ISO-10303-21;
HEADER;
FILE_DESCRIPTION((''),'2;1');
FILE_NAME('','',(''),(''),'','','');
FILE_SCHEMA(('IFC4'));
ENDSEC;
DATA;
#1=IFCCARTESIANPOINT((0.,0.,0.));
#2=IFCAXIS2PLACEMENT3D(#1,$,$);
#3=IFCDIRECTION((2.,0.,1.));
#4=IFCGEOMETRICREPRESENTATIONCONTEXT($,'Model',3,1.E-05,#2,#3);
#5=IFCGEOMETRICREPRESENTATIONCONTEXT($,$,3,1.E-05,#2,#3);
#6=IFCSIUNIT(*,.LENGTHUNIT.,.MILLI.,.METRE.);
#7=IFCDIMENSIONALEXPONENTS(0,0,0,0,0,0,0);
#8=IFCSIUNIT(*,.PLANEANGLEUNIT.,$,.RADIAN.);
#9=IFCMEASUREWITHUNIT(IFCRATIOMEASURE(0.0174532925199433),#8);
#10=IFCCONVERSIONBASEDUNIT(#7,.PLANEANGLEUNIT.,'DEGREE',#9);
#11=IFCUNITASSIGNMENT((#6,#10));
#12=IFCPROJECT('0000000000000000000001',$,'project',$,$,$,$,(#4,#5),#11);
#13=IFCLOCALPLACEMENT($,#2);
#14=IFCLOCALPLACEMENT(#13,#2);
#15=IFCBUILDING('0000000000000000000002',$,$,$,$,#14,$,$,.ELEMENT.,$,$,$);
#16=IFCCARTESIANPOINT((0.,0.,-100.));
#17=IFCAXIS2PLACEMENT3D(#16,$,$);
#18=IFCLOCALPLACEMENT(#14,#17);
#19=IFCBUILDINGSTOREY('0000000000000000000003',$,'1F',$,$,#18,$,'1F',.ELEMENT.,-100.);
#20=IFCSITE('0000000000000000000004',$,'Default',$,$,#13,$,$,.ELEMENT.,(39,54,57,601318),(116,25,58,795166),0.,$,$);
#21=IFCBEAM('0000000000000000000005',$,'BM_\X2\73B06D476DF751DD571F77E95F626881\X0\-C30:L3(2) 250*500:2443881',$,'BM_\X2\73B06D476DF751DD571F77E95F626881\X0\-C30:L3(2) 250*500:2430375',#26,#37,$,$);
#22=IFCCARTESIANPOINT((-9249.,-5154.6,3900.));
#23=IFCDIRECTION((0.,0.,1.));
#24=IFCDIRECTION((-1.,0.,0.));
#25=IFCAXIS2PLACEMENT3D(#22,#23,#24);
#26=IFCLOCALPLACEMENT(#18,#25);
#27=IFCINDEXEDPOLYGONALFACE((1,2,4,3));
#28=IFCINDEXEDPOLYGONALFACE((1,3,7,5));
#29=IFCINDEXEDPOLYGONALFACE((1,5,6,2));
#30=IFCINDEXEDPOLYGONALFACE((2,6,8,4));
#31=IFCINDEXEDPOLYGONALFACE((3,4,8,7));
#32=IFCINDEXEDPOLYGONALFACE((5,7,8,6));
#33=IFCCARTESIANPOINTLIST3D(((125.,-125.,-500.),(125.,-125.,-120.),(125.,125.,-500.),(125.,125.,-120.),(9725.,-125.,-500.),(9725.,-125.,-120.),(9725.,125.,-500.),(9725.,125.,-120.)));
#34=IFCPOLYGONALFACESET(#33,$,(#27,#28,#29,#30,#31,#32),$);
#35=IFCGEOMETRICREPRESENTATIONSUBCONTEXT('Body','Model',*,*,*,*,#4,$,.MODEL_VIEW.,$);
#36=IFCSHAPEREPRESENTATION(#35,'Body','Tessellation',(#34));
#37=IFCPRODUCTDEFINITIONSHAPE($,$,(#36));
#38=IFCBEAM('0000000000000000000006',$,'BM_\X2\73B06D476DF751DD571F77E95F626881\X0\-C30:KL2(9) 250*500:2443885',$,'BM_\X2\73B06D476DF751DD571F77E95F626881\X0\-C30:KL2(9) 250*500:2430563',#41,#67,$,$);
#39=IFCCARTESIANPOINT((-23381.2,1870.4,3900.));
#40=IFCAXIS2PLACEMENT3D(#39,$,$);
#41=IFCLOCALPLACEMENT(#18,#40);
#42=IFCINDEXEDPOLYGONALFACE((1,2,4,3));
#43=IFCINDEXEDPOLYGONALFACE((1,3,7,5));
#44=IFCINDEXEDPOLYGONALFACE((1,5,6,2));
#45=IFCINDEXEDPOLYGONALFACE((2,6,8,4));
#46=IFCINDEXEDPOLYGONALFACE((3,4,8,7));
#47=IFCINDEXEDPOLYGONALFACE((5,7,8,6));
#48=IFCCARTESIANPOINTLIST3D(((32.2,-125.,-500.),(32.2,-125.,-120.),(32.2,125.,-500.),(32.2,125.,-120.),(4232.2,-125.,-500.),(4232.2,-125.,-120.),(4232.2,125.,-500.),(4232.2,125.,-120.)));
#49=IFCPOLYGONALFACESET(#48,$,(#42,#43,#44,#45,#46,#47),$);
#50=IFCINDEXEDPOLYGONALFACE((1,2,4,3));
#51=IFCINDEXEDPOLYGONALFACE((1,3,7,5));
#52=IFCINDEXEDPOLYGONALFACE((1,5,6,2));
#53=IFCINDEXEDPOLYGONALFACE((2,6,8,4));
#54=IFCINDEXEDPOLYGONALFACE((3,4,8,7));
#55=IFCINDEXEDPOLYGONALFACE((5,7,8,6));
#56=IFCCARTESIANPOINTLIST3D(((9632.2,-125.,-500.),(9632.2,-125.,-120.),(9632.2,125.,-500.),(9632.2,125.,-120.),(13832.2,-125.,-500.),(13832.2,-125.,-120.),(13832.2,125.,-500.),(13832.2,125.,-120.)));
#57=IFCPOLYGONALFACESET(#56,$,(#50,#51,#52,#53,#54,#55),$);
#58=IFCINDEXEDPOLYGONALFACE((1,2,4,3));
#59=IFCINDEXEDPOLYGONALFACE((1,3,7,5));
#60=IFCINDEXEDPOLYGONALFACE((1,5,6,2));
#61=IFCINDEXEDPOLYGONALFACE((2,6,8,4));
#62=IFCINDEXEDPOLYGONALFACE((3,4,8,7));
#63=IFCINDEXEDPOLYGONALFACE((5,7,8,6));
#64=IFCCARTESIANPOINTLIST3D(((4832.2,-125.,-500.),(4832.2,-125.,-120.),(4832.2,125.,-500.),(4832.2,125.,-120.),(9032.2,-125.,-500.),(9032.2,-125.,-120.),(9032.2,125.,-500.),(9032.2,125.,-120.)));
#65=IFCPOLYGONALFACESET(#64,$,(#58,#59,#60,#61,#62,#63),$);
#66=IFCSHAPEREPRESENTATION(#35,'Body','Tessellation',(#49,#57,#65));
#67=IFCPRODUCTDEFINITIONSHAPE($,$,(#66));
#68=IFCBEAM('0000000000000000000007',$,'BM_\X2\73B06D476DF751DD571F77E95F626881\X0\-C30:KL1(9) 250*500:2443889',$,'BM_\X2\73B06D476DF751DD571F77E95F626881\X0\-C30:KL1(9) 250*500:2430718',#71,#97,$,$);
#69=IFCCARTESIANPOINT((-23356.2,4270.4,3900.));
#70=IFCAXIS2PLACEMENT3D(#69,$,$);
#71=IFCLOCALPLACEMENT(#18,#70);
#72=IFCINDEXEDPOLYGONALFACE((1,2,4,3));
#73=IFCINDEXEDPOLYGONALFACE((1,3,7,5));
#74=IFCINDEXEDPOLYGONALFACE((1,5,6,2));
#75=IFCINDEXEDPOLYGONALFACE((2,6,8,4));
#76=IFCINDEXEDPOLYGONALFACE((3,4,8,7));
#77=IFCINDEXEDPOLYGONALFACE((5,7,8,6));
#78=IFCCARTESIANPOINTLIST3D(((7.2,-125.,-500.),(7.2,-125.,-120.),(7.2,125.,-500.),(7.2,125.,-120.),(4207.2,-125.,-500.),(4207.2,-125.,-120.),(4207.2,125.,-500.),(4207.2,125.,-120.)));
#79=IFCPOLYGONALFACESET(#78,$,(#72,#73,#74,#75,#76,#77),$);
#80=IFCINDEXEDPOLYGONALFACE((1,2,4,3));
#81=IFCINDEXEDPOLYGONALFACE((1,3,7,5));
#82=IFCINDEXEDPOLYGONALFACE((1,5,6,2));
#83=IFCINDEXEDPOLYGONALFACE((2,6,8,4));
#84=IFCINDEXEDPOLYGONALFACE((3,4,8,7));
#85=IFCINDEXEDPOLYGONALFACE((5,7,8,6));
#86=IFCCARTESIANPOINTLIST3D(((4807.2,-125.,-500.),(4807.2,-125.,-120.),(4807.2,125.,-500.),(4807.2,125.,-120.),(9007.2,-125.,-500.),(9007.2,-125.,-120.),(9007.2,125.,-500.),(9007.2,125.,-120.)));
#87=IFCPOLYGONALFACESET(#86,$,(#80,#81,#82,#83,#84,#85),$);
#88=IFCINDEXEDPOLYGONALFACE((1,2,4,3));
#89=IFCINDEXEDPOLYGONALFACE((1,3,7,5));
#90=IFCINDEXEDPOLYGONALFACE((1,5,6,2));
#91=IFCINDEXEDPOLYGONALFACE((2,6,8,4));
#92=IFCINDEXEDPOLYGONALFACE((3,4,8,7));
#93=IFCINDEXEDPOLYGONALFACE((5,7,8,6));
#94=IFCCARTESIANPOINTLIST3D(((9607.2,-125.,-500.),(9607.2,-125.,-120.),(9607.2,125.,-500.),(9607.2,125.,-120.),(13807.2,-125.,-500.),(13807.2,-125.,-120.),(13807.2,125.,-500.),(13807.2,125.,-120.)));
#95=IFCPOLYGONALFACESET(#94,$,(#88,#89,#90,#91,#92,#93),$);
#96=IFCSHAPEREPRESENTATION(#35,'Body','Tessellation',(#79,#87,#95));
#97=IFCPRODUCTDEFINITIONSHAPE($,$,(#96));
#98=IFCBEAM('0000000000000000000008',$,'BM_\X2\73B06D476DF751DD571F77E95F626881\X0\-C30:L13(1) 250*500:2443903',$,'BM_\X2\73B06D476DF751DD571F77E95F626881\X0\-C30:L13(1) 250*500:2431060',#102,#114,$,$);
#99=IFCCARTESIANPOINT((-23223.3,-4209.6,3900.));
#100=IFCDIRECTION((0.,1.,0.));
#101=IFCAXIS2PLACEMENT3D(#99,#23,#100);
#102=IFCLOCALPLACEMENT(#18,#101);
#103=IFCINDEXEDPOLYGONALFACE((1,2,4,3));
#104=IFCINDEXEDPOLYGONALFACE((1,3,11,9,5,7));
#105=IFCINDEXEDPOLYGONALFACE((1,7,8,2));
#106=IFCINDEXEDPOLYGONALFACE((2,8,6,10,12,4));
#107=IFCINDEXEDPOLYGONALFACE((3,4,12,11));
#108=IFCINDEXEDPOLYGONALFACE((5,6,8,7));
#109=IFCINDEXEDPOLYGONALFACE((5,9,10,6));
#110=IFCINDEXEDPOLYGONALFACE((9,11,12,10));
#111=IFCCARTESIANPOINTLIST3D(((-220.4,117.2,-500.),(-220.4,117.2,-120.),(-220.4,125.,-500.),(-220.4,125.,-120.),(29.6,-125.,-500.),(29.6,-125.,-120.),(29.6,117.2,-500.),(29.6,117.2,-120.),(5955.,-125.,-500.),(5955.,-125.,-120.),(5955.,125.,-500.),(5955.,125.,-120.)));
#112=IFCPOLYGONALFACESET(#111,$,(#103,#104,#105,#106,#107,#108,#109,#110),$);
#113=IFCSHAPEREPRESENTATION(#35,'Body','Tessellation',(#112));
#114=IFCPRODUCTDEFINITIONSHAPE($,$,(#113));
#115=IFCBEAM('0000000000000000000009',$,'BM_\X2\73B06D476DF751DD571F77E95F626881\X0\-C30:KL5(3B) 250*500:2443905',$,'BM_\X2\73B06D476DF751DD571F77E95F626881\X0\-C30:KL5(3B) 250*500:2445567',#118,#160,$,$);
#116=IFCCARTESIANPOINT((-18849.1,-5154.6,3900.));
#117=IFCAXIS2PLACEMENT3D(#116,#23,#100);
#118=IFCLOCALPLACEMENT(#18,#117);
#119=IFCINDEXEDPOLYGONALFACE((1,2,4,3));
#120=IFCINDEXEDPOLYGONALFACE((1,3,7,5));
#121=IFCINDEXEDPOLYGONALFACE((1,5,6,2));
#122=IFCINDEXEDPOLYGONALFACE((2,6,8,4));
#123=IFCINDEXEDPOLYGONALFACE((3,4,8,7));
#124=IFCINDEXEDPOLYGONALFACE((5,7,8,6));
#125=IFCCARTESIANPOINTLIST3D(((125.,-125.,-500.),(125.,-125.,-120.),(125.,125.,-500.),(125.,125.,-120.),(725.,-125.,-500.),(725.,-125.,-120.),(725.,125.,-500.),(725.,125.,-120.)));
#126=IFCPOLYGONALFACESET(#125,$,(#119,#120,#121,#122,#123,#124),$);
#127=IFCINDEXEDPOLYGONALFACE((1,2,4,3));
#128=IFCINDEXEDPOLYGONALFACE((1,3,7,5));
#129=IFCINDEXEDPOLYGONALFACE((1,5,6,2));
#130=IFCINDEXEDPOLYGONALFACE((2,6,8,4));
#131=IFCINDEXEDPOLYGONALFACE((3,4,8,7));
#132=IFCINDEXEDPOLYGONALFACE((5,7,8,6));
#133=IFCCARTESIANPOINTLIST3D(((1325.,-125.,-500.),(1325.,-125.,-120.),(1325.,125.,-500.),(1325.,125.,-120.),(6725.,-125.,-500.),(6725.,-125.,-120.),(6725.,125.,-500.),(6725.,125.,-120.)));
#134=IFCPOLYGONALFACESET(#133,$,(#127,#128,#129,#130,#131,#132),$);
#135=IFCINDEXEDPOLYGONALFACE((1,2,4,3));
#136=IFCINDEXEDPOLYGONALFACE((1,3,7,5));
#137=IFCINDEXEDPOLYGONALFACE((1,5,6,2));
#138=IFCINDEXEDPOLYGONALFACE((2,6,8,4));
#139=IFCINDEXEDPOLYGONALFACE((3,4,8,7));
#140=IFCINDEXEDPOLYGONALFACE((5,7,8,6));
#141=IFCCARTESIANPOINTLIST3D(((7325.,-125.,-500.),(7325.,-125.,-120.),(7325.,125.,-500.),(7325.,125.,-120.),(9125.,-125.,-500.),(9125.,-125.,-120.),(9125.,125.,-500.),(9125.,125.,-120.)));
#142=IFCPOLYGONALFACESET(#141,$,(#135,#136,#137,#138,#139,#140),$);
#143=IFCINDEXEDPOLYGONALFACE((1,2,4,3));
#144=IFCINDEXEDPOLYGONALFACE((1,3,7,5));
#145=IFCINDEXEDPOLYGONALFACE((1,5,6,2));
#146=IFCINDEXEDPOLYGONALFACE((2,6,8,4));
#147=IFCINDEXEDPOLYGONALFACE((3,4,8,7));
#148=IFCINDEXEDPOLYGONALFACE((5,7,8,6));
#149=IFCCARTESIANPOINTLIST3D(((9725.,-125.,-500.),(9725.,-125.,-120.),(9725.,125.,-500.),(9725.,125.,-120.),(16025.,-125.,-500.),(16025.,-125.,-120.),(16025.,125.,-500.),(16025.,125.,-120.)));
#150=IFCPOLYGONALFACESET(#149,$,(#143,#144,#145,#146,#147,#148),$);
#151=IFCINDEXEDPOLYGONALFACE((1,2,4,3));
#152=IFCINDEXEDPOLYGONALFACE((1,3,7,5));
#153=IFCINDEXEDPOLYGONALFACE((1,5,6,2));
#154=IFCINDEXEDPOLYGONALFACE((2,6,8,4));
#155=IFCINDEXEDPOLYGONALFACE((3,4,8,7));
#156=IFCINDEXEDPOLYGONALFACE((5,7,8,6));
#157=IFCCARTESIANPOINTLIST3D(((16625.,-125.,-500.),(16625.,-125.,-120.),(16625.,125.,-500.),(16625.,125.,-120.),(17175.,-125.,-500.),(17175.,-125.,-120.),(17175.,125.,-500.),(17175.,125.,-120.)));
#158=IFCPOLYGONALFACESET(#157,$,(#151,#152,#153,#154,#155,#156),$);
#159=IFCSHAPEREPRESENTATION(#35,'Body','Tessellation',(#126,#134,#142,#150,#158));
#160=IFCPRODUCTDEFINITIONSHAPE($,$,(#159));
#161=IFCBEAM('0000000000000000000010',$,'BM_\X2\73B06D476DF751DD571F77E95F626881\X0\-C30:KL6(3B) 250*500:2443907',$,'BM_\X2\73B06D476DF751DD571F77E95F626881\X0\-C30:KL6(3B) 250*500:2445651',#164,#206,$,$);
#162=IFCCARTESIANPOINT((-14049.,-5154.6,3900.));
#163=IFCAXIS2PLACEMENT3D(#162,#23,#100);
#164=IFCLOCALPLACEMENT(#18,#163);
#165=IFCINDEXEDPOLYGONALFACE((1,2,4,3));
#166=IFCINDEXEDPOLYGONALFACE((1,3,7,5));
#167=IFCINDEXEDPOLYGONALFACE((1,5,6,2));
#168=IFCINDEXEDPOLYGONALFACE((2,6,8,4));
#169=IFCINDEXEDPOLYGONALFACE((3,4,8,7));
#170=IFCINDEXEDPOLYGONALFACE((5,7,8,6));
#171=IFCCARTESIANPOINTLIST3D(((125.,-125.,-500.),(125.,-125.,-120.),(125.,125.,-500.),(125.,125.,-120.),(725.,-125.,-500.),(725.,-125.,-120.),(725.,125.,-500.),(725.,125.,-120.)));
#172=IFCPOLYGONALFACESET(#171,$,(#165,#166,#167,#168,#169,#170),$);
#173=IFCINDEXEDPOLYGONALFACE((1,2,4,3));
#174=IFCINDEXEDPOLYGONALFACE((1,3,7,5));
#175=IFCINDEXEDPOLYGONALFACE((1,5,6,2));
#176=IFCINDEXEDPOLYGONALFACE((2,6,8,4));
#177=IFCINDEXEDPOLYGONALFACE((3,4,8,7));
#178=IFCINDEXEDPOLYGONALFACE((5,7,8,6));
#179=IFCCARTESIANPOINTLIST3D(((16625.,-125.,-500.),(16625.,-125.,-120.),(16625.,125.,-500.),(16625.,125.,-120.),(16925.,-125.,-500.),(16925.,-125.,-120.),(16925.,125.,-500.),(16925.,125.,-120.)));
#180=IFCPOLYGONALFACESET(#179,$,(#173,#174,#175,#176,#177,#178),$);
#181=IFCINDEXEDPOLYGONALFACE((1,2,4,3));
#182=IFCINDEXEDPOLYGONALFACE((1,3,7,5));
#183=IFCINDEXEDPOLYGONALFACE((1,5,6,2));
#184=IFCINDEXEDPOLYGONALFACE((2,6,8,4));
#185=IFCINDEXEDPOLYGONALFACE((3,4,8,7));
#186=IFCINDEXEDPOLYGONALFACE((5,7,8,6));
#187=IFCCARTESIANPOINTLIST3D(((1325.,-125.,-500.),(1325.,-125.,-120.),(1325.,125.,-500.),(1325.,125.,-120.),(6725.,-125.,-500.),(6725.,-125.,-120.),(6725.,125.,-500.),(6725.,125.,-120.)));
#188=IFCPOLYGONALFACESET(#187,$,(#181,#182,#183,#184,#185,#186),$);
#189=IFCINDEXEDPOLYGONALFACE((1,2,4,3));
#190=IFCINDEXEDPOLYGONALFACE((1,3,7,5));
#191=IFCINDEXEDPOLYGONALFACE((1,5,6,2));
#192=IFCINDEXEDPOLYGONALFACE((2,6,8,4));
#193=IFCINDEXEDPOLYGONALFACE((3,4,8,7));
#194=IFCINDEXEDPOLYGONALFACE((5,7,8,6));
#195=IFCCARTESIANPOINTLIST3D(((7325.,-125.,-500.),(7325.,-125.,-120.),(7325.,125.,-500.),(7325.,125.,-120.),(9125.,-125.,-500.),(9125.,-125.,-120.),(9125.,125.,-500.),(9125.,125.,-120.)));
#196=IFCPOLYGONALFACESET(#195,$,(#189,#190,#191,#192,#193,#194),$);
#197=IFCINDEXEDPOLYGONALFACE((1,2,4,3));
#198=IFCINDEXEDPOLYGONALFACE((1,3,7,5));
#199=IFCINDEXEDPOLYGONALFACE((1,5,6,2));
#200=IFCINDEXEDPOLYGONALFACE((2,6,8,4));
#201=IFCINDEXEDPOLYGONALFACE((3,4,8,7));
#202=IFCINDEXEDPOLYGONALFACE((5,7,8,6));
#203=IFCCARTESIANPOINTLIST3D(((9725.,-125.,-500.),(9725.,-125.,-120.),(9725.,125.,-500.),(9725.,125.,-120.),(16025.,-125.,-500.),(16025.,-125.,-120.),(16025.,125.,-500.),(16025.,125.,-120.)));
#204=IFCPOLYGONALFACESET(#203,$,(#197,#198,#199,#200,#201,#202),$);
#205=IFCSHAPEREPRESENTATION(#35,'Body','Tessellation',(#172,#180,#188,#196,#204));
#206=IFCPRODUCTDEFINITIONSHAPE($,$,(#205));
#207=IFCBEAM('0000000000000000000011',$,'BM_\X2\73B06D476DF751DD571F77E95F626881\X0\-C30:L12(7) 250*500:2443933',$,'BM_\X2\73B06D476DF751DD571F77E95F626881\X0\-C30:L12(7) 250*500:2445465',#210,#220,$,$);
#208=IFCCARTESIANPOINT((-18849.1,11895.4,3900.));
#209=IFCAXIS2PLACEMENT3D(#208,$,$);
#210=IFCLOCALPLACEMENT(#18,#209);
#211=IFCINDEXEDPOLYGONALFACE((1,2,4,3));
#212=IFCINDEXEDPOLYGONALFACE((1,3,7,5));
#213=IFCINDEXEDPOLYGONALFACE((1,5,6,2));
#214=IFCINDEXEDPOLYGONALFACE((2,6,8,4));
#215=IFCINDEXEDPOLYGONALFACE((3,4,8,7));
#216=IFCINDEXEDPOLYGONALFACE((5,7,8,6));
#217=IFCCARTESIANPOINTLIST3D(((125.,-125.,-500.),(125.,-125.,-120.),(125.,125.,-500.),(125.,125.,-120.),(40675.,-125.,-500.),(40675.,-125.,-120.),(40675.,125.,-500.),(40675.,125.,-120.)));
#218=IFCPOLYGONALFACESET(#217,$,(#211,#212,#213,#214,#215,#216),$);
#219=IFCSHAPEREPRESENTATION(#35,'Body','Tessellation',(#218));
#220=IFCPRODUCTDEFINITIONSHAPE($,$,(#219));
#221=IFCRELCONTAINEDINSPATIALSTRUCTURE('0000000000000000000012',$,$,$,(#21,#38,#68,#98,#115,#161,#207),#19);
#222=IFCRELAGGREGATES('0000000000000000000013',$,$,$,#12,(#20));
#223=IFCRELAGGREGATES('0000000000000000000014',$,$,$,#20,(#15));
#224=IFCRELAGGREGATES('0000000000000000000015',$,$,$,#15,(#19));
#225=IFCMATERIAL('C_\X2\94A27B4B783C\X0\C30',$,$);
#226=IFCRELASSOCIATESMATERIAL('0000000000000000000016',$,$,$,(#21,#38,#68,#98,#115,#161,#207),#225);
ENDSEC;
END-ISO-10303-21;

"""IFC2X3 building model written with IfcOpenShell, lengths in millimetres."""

from ifc_helpers import new_model, entity, si_unit, converted_unit, direction, frame, frame_2d, origin, origin_2d_with_axis, place, context, subcontext, project, spatial, polyline, rectangle, extrude, clip, bounded_halfspace, material, element, save


model = new_model("IFC2X3")

# Units and contexts
model_context = context("Model", 3, precision=1e-05, world=origin(), true_north=direction((2.0, 0.0, 1.0)))
context_of_model = context(None, 3, precision=1e-05, world=origin(), true_north=direction((2.0, 0.0, 1.0)))
body_context = subcontext(model_context, "Body", "Model", "MODEL_VIEW")
ifc_project = project(units=[si_unit("LENGTHUNIT", "METRE", prefix="MILLI"), converted_unit("PLANEANGLEUNIT", "DEGREE", entity("IfcRatioMeasure", 0.0174532925199433), si_unit("PLANEANGLEUNIT", "RADIAN"), dimensions=[0, 0, 0, 0, 0, 0, 0])], contexts=[model_context, context_of_model])

# Site, building, storey
site_placement = place(None, origin())
site = spatial("IfcSite", under=ifc_project, at=site_placement, Name="Default", CompositionType="ELEMENT", RefLatitude=(39, 54, 57, 601318), RefLongitude=(116, 25, 58, 795166), RefElevation=0.0)
building_placement = place(site_placement, origin())
building = spatial("IfcBuilding", under=site, at=building_placement, CompositionType="ELEMENT")
storey_placement = place(building_placement, frame((0.0, 0.0, -100.0)))
storey = spatial("IfcBuildingStorey", under=building, at=storey_placement, Name="1F", LongName="1F", CompositionType="ELEMENT", Elevation=-100.0)

# Beams
ifc_material = material(Name="C_钢筋砼C30")
beam_1_placement = place(storey_placement, frame((-9249.0, -5154.6, 3900.0), z_axis=(0.0, 0.0, 1.0), x_axis=(-1.0, 0.0, 0.0)))
element("IfcBeam", 1, at=beam_1_placement, inside=storey, material=ifc_material, Name="BM_现浇混凝土矩形梁-C30:L3(2) 250*500:2443881", ObjectType="BM_现浇混凝土矩形梁-C30:L3(2) 250*500:2430375", context=body_context, shape_type="SweptSolid", body=[
    extrude(rectangle(XDim=380.0, YDim=250.0, at=frame_2d((0.0, 0.0), x_axis=(1.0, 0.0))), frame((125.0, 0.0, -310.0), z_axis=(1.0, 0.0, 0.0), x_axis=(0.0, 0.0, -1.0)), (0.0, 0.0, 1.0), 9600.0),
])
beam_2_placement = place(storey_placement, frame((-23381.2, 1870.4, 3900.0)))
element("IfcBeam", 2, at=beam_2_placement, inside=storey, material=ifc_material, Name="BM_现浇混凝土矩形梁-C30:KL2(9) 250*500:2443885", ObjectType="BM_现浇混凝土矩形梁-C30:KL2(9) 250*500:2430563", context=body_context, shape_type="SweptSolid", body=[
    extrude(rectangle(XDim=380.0, YDim=250.0, at=frame_2d((0.0, 0.0), x_axis=(1.0, 0.0))), frame((32.2, 0.0, -310.0), z_axis=(1.0, 0.0, 0.0), x_axis=(0.0, 0.0, 1.0)), (0.0, 0.0, 1.0), 4200.0),
    extrude(rectangle(XDim=380.0, YDim=250.0, at=frame_2d((0.0, 0.0), x_axis=(1.0, 0.0))), frame((9632.2, 0.0, -310.0), z_axis=(1.0, 0.0, 0.0), x_axis=(0.0, 0.0, 1.0)), (0.0, 0.0, 1.0), 4200.0),
    extrude(rectangle(XDim=380.0, YDim=250.0, at=origin_2d_with_axis()), frame((4832.2, 0.0, -310.0), z_axis=(1.0, 0.0, 0.0), x_axis=(0.0, 0.0, 1.0)), (0.0, 0.0, 1.0), 4200.0),
])
beam_3_placement = place(storey_placement, frame((-23356.2, 4270.4, 3900.0)))
element("IfcBeam", 3, at=beam_3_placement, inside=storey, material=ifc_material, Name="BM_现浇混凝土矩形梁-C30:KL1(9) 250*500:2443889", ObjectType="BM_现浇混凝土矩形梁-C30:KL1(9) 250*500:2430718", context=body_context, shape_type="SweptSolid", body=[
    extrude(rectangle(XDim=380.0, YDim=250.0, at=origin_2d_with_axis()), frame((7.2, 0.0, -310.0), z_axis=(1.0, 0.0, 0.0), x_axis=(0.0, 0.0, 1.0)), (0.0, 0.0, 1.0), 4200.0),
    extrude(rectangle(XDim=380.0, YDim=250.0, at=frame_2d((0.0, 0.0), x_axis=(1.0, 0.0))), frame((4807.2, 0.0, -310.0), z_axis=(1.0, 0.0, 0.0), x_axis=(0.0, 0.0, 1.0)), (0.0, 0.0, 1.0), 4200.0),
    extrude(rectangle(XDim=380.0, YDim=250.0, at=origin_2d_with_axis()), frame((9607.2, 0.0, -310.0), z_axis=(1.0, 0.0, 0.0), x_axis=(0.0, 0.0, 1.0)), (0.0, 0.0, 1.0), 4200.0),
])
beam_4_placement = place(storey_placement, frame((-23223.3, -4209.6, 3900.0), z_axis=(0.0, 0.0, 1.0), x_axis=(0.0, 1.0, 0.0)))
element("IfcBeam", 4, at=beam_4_placement, inside=storey, material=ifc_material, Name="BM_现浇混凝土矩形梁-C30:L13(1) 250*500:2443903", ObjectType="BM_现浇混凝土矩形梁-C30:L13(1) 250*500:2431060", context=body_context, shape_type="Clipping", body=[
    clip(extrude(rectangle(XDim=380.0, YDim=250.0, at=origin_2d_with_axis()), frame((-220.4, 0.0, -310.0), z_axis=(1.0, 0.0, 0.0), x_axis=(0.0, 0.0, -1.0)), (0.0, 0.0, 1.0), 6175.4), bounded_halfspace(frame((29.6, 104.5, 0.0), z_axis=(-1.0, 0.0, 0.0), x_axis=(0.0, 0.0, -1.0)), False, frame((-220.4, 0.0, -310.0), z_axis=(1.0, 0.0, 0.0), x_axis=(0.0, 0.0, -1.0)), polyline([(190.0, 117.2), (190.0, -125.0), (-190.0, -125.0), (-190.0, 117.2), (190.0, 117.2)]))),
])
beam_5_placement = place(storey_placement, frame((-18849.1, -5154.6, 3900.0), z_axis=(0.0, 0.0, 1.0), x_axis=(0.0, 1.0, 0.0)))
element("IfcBeam", 5, at=beam_5_placement, inside=storey, material=ifc_material, Name="BM_现浇混凝土矩形梁-C30:KL5(3B) 250*500:2443905", ObjectType="BM_现浇混凝土矩形梁-C30:KL5(3B) 250*500:2445567", context=body_context, shape_type="SweptSolid", body=[
    extrude(rectangle(XDim=380.0, YDim=250.0, at=origin_2d_with_axis()), frame((125.0, 0.0, -310.0), z_axis=(1.0, 0.0, 0.0), x_axis=(0.0, 0.0, 1.0)), (0.0, 0.0, 1.0), 600.0),
    extrude(rectangle(XDim=380.0, YDim=250.0, at=origin_2d_with_axis()), frame((1325.0, 0.0, -310.0), z_axis=(1.0, 0.0, 0.0), x_axis=(0.0, 0.0, 1.0)), (0.0, 0.0, 1.0), 5400.0),
    extrude(rectangle(XDim=380.0, YDim=250.0, at=frame_2d((0.0, 0.0), x_axis=(1.0, 0.0))), frame((7325.0, 0.0, -310.0), z_axis=(1.0, 0.0, 0.0), x_axis=(0.0, 0.0, 1.0)), (0.0, 0.0, 1.0), 1800.0),
    extrude(rectangle(XDim=380.0, YDim=250.0, at=frame_2d((0.0, 0.0), x_axis=(1.0, 0.0))), frame((9725.0, 0.0, -310.0), z_axis=(1.0, 0.0, 0.0), x_axis=(0.0, 0.0, 1.0)), (0.0, 0.0, 1.0), 6300.0),
    extrude(rectangle(XDim=380.0, YDim=250.0, at=frame_2d((0.0, 0.0), x_axis=(1.0, 0.0))), frame((16625.0, 0.0, -310.0), z_axis=(1.0, 0.0, 0.0), x_axis=(0.0, 0.0, 1.0)), (0.0, 0.0, 1.0), 550.0),
])
beam_6_placement = place(storey_placement, frame((-14049.0, -5154.6, 3900.0), z_axis=(0.0, 0.0, 1.0), x_axis=(0.0, 1.0, 0.0)))
element("IfcBeam", 6, at=beam_6_placement, inside=storey, material=ifc_material, Name="BM_现浇混凝土矩形梁-C30:KL6(3B) 250*500:2443907", ObjectType="BM_现浇混凝土矩形梁-C30:KL6(3B) 250*500:2445651", context=body_context, shape_type="SweptSolid", body=[
    extrude(rectangle(XDim=380.0, YDim=250.0, at=origin_2d_with_axis()), frame((125.0, 0.0, -310.0), z_axis=(1.0, 0.0, 0.0), x_axis=(0.0, 0.0, 1.0)), (0.0, 0.0, 1.0), 600.0),
    extrude(rectangle(XDim=380.0, YDim=250.0, at=origin_2d_with_axis()), frame((16625.0, 0.0, -310.0), z_axis=(1.0, 0.0, 0.0), x_axis=(0.0, 0.0, 1.0)), (0.0, 0.0, 1.0), 300.0),
    extrude(rectangle(XDim=380.0, YDim=250.0, at=origin_2d_with_axis()), frame((1325.0, 0.0, -310.0), z_axis=(1.0, 0.0, 0.0), x_axis=(0.0, 0.0, 1.0)), (0.0, 0.0, 1.0), 5400.0),
    extrude(rectangle(XDim=380.0, YDim=250.0, at=origin_2d_with_axis()), frame((7325.0, 0.0, -310.0), z_axis=(1.0, 0.0, 0.0), x_axis=(0.0, 0.0, 1.0)), (0.0, 0.0, 1.0), 1800.0),
    extrude(rectangle(XDim=380.0, YDim=250.0, at=origin_2d_with_axis()), frame((9725.0, 0.0, -310.0), z_axis=(1.0, 0.0, 0.0), x_axis=(0.0, 0.0, 1.0)), (0.0, 0.0, 1.0), 6300.0),
])
beam_7_placement = place(storey_placement, frame((-18849.1, 11895.4, 3900.0)))
element("IfcBeam", 7, at=beam_7_placement, inside=storey, material=ifc_material, Name="BM_现浇混凝土矩形梁-C30:L12(7) 250*500:2443933", ObjectType="BM_现浇混凝土矩形梁-C30:L12(7) 250*500:2445465", context=body_context, shape_type="SweptSolid", body=[
    extrude(rectangle(XDim=380.0, YDim=250.0, at=frame_2d((0.0, 0.0), x_axis=(1.0, 0.0))), frame((125.0, 0.0, -310.0), z_axis=(1.0, 0.0, 0.0), x_axis=(0.0, 0.0, -1.0)), (0.0, 0.0, 1.0), 40550.0),
])

save(model, "model.ifc")
